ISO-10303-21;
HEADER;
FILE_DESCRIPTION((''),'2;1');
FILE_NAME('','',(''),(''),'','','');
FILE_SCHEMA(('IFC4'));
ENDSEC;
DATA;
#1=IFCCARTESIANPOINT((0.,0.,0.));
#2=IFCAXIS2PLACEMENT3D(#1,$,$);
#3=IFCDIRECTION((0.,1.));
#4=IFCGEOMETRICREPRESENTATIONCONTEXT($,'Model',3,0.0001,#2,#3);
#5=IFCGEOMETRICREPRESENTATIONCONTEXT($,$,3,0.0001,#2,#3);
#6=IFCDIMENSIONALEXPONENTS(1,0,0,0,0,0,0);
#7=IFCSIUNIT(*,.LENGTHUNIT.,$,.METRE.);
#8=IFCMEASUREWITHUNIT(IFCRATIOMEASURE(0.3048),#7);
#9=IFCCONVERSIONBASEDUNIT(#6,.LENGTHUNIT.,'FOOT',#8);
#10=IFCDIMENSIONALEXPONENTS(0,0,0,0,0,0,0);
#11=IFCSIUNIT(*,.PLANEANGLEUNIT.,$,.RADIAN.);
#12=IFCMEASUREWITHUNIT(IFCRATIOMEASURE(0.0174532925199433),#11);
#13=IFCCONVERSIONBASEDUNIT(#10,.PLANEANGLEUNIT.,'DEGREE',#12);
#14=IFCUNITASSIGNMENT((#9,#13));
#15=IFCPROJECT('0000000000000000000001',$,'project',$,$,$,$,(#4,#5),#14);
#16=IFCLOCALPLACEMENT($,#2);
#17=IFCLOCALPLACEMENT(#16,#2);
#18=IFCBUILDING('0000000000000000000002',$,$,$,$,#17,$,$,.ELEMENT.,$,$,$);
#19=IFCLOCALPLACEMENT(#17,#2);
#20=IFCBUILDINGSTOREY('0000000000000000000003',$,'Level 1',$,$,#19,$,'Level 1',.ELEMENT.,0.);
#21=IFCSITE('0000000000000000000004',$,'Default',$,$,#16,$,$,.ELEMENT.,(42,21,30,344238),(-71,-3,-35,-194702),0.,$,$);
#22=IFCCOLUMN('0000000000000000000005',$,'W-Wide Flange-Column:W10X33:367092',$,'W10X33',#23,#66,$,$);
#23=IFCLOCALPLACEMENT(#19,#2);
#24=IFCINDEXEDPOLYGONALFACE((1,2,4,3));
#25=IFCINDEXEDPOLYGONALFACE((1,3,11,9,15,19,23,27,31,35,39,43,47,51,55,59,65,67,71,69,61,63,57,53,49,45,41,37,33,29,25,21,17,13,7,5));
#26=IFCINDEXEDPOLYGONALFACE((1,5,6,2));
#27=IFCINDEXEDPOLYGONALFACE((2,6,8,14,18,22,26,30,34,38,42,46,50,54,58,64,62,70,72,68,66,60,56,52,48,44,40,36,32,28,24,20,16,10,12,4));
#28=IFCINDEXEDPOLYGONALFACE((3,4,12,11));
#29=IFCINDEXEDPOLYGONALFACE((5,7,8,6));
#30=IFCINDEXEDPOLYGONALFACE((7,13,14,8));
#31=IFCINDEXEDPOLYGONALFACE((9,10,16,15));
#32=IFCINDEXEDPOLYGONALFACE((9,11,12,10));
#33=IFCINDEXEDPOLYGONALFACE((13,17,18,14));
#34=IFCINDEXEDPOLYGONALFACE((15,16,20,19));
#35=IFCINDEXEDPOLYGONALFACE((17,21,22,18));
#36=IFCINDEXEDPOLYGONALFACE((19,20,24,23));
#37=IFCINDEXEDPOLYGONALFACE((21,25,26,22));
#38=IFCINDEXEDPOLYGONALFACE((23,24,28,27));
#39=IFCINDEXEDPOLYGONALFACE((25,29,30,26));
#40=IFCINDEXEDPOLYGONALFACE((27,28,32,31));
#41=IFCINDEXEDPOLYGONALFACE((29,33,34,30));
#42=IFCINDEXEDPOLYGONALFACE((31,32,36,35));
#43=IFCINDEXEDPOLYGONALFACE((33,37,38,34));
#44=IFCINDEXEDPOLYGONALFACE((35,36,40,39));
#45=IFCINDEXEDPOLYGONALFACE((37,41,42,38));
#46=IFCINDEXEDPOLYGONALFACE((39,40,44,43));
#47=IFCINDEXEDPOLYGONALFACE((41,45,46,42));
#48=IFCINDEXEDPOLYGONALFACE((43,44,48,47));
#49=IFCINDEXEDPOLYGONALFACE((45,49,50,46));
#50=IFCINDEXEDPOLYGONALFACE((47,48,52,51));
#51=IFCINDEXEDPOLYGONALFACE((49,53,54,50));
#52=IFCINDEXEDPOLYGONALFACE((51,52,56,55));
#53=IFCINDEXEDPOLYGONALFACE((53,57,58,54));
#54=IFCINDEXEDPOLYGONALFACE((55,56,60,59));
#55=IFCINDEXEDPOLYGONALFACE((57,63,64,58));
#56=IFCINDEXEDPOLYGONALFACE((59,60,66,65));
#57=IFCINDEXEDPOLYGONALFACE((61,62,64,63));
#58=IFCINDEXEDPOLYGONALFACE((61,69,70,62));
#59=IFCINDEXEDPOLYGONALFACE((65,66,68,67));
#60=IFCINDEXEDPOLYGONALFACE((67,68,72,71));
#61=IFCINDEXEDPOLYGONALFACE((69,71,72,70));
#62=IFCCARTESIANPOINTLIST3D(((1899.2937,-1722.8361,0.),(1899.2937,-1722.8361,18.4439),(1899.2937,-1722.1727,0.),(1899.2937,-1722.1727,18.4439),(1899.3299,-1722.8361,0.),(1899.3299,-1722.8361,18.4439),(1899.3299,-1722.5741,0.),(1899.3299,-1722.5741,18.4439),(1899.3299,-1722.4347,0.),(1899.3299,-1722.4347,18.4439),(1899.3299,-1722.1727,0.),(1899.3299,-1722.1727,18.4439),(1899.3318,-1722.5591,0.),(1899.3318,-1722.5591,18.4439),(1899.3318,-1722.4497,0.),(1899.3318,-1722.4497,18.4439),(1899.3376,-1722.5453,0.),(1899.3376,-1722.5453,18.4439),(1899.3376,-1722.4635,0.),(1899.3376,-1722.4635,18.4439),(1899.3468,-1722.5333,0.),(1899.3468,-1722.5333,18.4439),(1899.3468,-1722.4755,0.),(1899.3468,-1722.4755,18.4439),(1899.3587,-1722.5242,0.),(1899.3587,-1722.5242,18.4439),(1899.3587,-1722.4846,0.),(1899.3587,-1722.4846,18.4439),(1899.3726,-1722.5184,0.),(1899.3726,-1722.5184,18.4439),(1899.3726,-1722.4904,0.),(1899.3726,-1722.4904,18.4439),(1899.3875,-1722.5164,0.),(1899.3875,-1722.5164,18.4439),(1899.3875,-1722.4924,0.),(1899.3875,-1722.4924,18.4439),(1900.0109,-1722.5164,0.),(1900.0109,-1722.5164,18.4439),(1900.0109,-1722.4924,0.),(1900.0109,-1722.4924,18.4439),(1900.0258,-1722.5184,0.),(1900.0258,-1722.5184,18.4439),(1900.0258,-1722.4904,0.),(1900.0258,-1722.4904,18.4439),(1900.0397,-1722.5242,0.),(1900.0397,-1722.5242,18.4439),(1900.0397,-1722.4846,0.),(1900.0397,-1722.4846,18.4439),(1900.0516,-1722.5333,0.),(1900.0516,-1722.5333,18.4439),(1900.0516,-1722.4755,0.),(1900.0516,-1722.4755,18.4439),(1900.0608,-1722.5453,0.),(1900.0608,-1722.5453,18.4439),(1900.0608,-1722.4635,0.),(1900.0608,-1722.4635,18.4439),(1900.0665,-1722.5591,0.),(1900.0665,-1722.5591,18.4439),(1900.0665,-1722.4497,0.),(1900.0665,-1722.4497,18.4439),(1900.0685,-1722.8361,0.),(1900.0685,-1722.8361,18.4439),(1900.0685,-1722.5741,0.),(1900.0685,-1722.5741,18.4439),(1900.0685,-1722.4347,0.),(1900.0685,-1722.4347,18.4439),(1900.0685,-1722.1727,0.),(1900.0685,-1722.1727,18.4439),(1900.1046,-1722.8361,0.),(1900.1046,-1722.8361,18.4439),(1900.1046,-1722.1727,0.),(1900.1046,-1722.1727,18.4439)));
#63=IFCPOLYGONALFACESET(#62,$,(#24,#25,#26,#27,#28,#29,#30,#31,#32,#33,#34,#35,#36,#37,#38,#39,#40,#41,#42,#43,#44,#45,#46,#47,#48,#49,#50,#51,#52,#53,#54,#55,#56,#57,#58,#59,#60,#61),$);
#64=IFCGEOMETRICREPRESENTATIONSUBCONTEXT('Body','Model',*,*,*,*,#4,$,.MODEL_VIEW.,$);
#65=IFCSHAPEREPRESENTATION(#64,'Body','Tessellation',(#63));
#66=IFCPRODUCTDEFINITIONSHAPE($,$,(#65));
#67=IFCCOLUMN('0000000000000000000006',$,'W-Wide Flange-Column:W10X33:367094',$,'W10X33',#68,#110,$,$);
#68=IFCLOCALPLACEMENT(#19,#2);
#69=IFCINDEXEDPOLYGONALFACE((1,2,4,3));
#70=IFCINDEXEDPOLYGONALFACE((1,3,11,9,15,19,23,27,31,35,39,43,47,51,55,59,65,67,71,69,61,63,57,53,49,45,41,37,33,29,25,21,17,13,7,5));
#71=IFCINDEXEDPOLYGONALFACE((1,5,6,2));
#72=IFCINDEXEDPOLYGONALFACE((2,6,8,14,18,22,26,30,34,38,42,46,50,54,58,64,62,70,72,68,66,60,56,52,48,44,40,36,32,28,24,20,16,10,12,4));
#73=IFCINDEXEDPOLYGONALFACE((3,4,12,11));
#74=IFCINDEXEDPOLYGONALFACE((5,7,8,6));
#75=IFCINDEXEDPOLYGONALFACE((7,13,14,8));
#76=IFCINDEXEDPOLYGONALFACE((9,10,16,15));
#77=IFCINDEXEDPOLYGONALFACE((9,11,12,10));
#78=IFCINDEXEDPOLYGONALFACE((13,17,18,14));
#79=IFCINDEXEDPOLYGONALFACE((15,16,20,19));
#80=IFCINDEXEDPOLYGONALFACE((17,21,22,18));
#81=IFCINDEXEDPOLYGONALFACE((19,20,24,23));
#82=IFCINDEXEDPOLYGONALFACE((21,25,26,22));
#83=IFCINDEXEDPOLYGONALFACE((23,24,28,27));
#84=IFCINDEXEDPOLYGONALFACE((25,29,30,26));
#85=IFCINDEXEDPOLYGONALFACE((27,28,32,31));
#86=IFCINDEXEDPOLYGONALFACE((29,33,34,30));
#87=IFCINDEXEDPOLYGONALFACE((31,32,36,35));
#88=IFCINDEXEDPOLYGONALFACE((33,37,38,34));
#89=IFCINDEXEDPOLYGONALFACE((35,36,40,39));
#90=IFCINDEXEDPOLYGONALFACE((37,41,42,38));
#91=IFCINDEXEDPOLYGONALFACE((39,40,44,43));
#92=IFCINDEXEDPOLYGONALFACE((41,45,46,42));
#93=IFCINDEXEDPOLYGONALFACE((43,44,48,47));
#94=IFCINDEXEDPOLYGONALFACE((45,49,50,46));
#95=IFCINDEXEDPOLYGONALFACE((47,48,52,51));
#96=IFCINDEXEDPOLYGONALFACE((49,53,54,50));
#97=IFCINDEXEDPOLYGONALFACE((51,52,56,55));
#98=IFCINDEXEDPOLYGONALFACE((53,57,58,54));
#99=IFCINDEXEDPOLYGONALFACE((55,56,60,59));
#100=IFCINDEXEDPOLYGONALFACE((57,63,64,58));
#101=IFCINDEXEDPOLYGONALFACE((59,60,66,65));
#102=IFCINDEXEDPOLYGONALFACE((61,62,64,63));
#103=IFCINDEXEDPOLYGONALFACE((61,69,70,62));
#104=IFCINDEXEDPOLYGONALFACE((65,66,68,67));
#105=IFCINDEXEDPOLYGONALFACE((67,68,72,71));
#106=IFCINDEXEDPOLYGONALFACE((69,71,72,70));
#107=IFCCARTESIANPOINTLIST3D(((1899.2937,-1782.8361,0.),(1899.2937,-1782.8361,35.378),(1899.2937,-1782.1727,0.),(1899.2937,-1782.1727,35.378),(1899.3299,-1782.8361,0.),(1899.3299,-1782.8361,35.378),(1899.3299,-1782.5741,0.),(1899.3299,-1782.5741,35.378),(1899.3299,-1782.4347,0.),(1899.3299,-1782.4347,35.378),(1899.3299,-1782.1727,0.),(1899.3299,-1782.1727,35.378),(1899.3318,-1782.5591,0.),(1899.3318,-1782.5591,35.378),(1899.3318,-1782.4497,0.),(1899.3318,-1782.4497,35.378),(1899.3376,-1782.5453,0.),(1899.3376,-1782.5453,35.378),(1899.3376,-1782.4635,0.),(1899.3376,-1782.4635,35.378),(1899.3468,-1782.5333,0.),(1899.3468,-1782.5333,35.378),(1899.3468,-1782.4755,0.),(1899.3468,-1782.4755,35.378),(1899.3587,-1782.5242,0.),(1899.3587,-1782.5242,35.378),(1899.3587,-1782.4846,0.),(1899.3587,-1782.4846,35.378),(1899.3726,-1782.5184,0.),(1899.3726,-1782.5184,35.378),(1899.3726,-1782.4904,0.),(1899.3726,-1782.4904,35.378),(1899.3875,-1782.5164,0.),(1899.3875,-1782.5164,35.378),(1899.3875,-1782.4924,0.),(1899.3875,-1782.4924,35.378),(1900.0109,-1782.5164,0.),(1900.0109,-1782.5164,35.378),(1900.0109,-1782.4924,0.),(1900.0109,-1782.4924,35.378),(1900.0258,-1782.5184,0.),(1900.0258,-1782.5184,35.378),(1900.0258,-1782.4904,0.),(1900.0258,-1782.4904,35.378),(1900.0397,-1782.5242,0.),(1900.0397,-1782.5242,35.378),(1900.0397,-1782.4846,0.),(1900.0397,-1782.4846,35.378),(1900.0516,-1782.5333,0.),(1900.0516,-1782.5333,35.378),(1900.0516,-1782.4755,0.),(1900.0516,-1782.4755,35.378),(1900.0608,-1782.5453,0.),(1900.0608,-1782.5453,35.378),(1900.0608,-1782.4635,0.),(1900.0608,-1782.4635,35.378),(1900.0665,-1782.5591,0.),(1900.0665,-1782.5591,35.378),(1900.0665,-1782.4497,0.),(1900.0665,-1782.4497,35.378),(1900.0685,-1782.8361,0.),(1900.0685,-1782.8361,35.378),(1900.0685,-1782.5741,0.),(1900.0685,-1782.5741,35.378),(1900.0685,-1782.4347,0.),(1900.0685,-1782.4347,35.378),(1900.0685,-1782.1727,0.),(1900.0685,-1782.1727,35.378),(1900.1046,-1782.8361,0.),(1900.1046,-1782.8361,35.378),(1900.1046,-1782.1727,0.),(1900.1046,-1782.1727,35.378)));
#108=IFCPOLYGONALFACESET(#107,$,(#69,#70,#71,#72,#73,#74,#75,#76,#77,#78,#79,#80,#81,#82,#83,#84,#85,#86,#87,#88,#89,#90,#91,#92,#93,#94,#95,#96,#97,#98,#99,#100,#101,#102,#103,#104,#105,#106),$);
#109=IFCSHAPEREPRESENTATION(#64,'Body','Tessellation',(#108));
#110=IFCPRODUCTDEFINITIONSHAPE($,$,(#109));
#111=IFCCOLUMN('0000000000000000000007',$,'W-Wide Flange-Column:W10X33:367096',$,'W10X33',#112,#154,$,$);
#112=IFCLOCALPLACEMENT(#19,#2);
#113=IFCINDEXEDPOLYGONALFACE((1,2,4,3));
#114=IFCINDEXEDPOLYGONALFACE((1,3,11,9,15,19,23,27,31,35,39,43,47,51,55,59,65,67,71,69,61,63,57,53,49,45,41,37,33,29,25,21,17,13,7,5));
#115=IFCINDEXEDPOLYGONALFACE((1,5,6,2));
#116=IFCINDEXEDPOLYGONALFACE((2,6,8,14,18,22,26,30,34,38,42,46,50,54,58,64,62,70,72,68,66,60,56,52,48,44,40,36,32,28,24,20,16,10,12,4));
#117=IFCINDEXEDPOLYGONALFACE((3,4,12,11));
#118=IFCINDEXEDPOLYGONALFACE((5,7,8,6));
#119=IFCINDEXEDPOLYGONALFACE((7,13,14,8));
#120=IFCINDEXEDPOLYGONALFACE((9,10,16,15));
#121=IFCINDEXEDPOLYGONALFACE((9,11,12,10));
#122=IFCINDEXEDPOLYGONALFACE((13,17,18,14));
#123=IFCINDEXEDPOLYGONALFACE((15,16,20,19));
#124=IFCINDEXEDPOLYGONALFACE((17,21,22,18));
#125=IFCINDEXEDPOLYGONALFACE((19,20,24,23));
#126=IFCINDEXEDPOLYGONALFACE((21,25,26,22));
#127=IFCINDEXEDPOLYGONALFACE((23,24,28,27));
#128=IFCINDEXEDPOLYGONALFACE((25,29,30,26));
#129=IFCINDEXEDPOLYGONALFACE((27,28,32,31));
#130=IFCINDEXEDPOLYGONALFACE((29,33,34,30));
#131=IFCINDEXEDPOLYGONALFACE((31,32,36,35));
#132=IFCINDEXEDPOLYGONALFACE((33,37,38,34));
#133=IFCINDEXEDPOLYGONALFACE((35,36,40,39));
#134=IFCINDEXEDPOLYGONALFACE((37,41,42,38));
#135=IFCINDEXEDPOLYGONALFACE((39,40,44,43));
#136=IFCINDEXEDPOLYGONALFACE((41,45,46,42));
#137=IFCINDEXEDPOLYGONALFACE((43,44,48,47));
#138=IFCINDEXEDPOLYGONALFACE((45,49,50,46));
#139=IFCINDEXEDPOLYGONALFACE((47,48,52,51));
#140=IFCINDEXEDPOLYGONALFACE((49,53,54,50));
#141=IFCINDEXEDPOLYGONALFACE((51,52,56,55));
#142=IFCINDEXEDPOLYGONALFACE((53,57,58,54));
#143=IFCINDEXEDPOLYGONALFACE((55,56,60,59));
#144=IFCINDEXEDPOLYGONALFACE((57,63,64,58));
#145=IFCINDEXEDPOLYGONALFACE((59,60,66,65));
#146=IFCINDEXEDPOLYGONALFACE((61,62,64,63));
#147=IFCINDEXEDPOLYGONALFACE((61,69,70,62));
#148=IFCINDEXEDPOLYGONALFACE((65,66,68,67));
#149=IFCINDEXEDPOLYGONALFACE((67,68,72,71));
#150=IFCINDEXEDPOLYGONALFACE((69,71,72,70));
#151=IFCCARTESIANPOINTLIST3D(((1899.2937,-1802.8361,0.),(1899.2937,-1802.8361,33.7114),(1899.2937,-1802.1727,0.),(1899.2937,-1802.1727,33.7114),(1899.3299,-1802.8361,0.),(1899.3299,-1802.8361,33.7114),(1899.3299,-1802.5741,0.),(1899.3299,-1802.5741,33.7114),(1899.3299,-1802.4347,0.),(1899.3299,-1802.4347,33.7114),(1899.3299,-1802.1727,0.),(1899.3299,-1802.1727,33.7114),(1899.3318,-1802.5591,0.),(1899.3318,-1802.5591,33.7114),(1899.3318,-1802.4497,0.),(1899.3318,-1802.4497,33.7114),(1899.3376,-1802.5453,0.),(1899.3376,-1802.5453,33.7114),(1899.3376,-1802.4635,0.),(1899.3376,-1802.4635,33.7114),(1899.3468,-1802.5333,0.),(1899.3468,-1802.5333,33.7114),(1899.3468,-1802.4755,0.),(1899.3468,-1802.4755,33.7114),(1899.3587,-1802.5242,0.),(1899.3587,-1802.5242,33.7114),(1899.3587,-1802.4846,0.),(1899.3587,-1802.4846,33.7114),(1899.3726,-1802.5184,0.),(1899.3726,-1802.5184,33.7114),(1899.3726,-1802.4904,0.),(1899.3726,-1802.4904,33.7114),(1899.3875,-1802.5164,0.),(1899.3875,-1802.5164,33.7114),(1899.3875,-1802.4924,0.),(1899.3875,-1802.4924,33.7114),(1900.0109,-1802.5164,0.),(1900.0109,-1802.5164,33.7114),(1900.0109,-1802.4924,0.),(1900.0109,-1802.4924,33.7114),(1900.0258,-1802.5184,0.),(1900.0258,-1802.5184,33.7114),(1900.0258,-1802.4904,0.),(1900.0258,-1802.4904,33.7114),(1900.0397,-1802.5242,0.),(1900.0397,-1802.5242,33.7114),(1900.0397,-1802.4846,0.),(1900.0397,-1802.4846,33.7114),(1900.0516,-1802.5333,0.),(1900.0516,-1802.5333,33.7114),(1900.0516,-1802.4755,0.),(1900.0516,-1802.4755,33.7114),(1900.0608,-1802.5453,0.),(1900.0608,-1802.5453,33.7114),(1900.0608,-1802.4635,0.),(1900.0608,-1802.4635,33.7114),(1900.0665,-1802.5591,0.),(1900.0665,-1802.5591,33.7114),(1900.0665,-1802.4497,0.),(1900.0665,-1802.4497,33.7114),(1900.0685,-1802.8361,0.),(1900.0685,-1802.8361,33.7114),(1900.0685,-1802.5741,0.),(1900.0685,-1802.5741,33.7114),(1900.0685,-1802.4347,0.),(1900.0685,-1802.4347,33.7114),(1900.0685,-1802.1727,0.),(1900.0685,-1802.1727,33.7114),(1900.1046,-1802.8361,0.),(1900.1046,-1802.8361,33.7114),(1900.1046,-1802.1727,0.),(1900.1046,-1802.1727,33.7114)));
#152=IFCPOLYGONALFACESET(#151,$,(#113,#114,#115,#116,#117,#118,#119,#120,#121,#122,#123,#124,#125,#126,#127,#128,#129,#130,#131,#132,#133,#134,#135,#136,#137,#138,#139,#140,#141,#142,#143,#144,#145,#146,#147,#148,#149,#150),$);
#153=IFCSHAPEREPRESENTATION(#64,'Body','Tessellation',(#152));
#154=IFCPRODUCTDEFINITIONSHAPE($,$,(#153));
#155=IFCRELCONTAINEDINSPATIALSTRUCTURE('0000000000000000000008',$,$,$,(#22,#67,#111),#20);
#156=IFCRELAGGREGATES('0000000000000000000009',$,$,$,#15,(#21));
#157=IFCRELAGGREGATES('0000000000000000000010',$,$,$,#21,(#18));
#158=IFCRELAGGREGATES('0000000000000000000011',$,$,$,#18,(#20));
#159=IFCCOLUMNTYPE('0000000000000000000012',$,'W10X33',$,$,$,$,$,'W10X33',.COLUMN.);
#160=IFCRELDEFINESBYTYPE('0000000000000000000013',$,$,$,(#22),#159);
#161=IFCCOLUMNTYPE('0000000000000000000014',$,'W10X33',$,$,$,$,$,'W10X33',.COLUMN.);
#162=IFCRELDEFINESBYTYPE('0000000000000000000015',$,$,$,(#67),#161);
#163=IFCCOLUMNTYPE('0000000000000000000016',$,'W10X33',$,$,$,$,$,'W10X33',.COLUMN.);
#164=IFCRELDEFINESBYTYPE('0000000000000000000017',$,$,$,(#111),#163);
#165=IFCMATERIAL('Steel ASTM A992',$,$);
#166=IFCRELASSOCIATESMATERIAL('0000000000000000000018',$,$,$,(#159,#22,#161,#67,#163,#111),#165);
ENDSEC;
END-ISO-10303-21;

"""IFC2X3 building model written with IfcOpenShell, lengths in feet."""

from ifc_helpers import new_model, entity, si_unit, converted_unit, direction, frame, frame_2d, origin, place, context, subcontext, project, spatial, i_section, extrude, source, transform, mapped, material, type_object, type_shapes, element, save


model = new_model("IFC2X3")

# Units and contexts
model_context = context("Model", 3, precision=0.0001, world=origin(), true_north=direction((0.0, 1.0)))
context_of_model = context(None, 3, precision=0.0001, world=origin(), true_north=direction((0.0, 1.0)))
body_context = subcontext(model_context, "Body", "Model", "MODEL_VIEW")
ifc_project = project(units=[converted_unit("LENGTHUNIT", "FOOT", entity("IfcRatioMeasure", 0.3048), si_unit("LENGTHUNIT", "METRE"), dimensions=[1, 0, 0, 0, 0, 0, 0]), converted_unit("PLANEANGLEUNIT", "DEGREE", entity("IfcRatioMeasure", 0.0174532925199433), si_unit("PLANEANGLEUNIT", "RADIAN"), dimensions=[0, 0, 0, 0, 0, 0, 0])], contexts=[model_context, context_of_model])

# Site, building, storey
site_placement = place(None, origin())
site = spatial("IfcSite", under=ifc_project, at=site_placement, Name="Default", CompositionType="ELEMENT", RefLatitude=(42, 21, 30, 344238), RefLongitude=(-71, -3, -35, -194702), RefElevation=0.0)
building_placement = place(site_placement, origin())
building = spatial("IfcBuilding", under=site, at=building_placement, CompositionType="ELEMENT")
storey_placement = place(building_placement, origin())
storey = spatial("IfcBuildingStorey", under=building, at=storey_placement, Name="Level 1", LongName="Level 1", CompositionType="ELEMENT", Elevation=0.0)

# Columns
ifc_material_1 = material(Name="Steel ASTM A992")
column_type_1 = type_object("IfcColumnType", Name="W10X33", ElementType="W10X33", PredefinedType="COLUMN", material=ifc_material_1)
shared_shape_1 = source(origin(), body_context, "Body", "SweptSolid", [
    extrude(i_section(OverallWidth=0.6634, OverallDepth=0.8109, WebThickness=0.0241, FlangeThickness=0.0361, FilletRadius=0.0576, at=frame_2d((0.0, 0.0), x_axis=(1.0, 0.0))), frame((1899.6992, -1722.5044, 0.0), z_axis=(0.0, 0.0, 1.0), x_axis=(0.0, -1.0, 0.0)), (0.0, 0.0, 1.0), 18.4439),
])
type_shapes(column_type_1, [shared_shape_1])
column_1_placement = place(storey_placement, origin())
element("IfcColumn", 1, at=column_1_placement, inside=storey, type_object=column_type_1, material=ifc_material_1, Name="W-Wide Flange-Column:W10X33:367092", ObjectType="W10X33", context=body_context, shape_type="MappedRepresentation", body=[
    mapped(shared_shape_1, transform((0.0, 0.0, 0.0), scale=1.0)),
])
column_type_2 = type_object("IfcColumnType", Name="W10X33", ElementType="W10X33", PredefinedType="COLUMN", material=ifc_material_1)
shared_shape_2 = source(origin(), body_context, "Body", "SweptSolid", [
    extrude(i_section(OverallWidth=0.6634, OverallDepth=0.8109, WebThickness=0.0241, FlangeThickness=0.0361, FilletRadius=0.0576, at=frame_2d((0.0, 0.0), x_axis=(1.0, 0.0))), frame((1899.6992, -1782.5044, 0.0), z_axis=(0.0, 0.0, 1.0), x_axis=(0.0, -1.0, 0.0)), (0.0, 0.0, 1.0), 35.378),
])
type_shapes(column_type_2, [shared_shape_2])
column_2_placement = place(storey_placement, origin())
element("IfcColumn", 2, at=column_2_placement, inside=storey, type_object=column_type_2, material=ifc_material_1, Name="W-Wide Flange-Column:W10X33:367094", ObjectType="W10X33", context=body_context, shape_type="MappedRepresentation", body=[
    mapped(shared_shape_2, transform((0.0, 0.0, 0.0), scale=1.0)),
])
column_type_3 = type_object("IfcColumnType", Name="W10X33", ElementType="W10X33", PredefinedType="COLUMN", material=ifc_material_1)
shared_shape_3 = source(origin(), body_context, "Body", "SweptSolid", [
    extrude(i_section(OverallWidth=0.6634, OverallDepth=0.8109, WebThickness=0.0241, FlangeThickness=0.0361, FilletRadius=0.0576, at=frame_2d((0.0, 0.0), x_axis=(1.0, 0.0))), frame((1899.6992, -1802.5044, 0.0), z_axis=(0.0, 0.0, 1.0), x_axis=(0.0, -1.0, 0.0)), (0.0, 0.0, 1.0), 33.7114),
])
type_shapes(column_type_3, [shared_shape_3])
column_3_placement = place(storey_placement, origin())
element("IfcColumn", 3, at=column_3_placement, inside=storey, type_object=column_type_3, material=ifc_material_1, Name="W-Wide Flange-Column:W10X33:367096", ObjectType="W10X33", context=body_context, shape_type="MappedRepresentation", body=[
    mapped(shared_shape_3, transform((0.0, 0.0, 0.0), scale=1.0)),
])

save(model, "model.ifc")
